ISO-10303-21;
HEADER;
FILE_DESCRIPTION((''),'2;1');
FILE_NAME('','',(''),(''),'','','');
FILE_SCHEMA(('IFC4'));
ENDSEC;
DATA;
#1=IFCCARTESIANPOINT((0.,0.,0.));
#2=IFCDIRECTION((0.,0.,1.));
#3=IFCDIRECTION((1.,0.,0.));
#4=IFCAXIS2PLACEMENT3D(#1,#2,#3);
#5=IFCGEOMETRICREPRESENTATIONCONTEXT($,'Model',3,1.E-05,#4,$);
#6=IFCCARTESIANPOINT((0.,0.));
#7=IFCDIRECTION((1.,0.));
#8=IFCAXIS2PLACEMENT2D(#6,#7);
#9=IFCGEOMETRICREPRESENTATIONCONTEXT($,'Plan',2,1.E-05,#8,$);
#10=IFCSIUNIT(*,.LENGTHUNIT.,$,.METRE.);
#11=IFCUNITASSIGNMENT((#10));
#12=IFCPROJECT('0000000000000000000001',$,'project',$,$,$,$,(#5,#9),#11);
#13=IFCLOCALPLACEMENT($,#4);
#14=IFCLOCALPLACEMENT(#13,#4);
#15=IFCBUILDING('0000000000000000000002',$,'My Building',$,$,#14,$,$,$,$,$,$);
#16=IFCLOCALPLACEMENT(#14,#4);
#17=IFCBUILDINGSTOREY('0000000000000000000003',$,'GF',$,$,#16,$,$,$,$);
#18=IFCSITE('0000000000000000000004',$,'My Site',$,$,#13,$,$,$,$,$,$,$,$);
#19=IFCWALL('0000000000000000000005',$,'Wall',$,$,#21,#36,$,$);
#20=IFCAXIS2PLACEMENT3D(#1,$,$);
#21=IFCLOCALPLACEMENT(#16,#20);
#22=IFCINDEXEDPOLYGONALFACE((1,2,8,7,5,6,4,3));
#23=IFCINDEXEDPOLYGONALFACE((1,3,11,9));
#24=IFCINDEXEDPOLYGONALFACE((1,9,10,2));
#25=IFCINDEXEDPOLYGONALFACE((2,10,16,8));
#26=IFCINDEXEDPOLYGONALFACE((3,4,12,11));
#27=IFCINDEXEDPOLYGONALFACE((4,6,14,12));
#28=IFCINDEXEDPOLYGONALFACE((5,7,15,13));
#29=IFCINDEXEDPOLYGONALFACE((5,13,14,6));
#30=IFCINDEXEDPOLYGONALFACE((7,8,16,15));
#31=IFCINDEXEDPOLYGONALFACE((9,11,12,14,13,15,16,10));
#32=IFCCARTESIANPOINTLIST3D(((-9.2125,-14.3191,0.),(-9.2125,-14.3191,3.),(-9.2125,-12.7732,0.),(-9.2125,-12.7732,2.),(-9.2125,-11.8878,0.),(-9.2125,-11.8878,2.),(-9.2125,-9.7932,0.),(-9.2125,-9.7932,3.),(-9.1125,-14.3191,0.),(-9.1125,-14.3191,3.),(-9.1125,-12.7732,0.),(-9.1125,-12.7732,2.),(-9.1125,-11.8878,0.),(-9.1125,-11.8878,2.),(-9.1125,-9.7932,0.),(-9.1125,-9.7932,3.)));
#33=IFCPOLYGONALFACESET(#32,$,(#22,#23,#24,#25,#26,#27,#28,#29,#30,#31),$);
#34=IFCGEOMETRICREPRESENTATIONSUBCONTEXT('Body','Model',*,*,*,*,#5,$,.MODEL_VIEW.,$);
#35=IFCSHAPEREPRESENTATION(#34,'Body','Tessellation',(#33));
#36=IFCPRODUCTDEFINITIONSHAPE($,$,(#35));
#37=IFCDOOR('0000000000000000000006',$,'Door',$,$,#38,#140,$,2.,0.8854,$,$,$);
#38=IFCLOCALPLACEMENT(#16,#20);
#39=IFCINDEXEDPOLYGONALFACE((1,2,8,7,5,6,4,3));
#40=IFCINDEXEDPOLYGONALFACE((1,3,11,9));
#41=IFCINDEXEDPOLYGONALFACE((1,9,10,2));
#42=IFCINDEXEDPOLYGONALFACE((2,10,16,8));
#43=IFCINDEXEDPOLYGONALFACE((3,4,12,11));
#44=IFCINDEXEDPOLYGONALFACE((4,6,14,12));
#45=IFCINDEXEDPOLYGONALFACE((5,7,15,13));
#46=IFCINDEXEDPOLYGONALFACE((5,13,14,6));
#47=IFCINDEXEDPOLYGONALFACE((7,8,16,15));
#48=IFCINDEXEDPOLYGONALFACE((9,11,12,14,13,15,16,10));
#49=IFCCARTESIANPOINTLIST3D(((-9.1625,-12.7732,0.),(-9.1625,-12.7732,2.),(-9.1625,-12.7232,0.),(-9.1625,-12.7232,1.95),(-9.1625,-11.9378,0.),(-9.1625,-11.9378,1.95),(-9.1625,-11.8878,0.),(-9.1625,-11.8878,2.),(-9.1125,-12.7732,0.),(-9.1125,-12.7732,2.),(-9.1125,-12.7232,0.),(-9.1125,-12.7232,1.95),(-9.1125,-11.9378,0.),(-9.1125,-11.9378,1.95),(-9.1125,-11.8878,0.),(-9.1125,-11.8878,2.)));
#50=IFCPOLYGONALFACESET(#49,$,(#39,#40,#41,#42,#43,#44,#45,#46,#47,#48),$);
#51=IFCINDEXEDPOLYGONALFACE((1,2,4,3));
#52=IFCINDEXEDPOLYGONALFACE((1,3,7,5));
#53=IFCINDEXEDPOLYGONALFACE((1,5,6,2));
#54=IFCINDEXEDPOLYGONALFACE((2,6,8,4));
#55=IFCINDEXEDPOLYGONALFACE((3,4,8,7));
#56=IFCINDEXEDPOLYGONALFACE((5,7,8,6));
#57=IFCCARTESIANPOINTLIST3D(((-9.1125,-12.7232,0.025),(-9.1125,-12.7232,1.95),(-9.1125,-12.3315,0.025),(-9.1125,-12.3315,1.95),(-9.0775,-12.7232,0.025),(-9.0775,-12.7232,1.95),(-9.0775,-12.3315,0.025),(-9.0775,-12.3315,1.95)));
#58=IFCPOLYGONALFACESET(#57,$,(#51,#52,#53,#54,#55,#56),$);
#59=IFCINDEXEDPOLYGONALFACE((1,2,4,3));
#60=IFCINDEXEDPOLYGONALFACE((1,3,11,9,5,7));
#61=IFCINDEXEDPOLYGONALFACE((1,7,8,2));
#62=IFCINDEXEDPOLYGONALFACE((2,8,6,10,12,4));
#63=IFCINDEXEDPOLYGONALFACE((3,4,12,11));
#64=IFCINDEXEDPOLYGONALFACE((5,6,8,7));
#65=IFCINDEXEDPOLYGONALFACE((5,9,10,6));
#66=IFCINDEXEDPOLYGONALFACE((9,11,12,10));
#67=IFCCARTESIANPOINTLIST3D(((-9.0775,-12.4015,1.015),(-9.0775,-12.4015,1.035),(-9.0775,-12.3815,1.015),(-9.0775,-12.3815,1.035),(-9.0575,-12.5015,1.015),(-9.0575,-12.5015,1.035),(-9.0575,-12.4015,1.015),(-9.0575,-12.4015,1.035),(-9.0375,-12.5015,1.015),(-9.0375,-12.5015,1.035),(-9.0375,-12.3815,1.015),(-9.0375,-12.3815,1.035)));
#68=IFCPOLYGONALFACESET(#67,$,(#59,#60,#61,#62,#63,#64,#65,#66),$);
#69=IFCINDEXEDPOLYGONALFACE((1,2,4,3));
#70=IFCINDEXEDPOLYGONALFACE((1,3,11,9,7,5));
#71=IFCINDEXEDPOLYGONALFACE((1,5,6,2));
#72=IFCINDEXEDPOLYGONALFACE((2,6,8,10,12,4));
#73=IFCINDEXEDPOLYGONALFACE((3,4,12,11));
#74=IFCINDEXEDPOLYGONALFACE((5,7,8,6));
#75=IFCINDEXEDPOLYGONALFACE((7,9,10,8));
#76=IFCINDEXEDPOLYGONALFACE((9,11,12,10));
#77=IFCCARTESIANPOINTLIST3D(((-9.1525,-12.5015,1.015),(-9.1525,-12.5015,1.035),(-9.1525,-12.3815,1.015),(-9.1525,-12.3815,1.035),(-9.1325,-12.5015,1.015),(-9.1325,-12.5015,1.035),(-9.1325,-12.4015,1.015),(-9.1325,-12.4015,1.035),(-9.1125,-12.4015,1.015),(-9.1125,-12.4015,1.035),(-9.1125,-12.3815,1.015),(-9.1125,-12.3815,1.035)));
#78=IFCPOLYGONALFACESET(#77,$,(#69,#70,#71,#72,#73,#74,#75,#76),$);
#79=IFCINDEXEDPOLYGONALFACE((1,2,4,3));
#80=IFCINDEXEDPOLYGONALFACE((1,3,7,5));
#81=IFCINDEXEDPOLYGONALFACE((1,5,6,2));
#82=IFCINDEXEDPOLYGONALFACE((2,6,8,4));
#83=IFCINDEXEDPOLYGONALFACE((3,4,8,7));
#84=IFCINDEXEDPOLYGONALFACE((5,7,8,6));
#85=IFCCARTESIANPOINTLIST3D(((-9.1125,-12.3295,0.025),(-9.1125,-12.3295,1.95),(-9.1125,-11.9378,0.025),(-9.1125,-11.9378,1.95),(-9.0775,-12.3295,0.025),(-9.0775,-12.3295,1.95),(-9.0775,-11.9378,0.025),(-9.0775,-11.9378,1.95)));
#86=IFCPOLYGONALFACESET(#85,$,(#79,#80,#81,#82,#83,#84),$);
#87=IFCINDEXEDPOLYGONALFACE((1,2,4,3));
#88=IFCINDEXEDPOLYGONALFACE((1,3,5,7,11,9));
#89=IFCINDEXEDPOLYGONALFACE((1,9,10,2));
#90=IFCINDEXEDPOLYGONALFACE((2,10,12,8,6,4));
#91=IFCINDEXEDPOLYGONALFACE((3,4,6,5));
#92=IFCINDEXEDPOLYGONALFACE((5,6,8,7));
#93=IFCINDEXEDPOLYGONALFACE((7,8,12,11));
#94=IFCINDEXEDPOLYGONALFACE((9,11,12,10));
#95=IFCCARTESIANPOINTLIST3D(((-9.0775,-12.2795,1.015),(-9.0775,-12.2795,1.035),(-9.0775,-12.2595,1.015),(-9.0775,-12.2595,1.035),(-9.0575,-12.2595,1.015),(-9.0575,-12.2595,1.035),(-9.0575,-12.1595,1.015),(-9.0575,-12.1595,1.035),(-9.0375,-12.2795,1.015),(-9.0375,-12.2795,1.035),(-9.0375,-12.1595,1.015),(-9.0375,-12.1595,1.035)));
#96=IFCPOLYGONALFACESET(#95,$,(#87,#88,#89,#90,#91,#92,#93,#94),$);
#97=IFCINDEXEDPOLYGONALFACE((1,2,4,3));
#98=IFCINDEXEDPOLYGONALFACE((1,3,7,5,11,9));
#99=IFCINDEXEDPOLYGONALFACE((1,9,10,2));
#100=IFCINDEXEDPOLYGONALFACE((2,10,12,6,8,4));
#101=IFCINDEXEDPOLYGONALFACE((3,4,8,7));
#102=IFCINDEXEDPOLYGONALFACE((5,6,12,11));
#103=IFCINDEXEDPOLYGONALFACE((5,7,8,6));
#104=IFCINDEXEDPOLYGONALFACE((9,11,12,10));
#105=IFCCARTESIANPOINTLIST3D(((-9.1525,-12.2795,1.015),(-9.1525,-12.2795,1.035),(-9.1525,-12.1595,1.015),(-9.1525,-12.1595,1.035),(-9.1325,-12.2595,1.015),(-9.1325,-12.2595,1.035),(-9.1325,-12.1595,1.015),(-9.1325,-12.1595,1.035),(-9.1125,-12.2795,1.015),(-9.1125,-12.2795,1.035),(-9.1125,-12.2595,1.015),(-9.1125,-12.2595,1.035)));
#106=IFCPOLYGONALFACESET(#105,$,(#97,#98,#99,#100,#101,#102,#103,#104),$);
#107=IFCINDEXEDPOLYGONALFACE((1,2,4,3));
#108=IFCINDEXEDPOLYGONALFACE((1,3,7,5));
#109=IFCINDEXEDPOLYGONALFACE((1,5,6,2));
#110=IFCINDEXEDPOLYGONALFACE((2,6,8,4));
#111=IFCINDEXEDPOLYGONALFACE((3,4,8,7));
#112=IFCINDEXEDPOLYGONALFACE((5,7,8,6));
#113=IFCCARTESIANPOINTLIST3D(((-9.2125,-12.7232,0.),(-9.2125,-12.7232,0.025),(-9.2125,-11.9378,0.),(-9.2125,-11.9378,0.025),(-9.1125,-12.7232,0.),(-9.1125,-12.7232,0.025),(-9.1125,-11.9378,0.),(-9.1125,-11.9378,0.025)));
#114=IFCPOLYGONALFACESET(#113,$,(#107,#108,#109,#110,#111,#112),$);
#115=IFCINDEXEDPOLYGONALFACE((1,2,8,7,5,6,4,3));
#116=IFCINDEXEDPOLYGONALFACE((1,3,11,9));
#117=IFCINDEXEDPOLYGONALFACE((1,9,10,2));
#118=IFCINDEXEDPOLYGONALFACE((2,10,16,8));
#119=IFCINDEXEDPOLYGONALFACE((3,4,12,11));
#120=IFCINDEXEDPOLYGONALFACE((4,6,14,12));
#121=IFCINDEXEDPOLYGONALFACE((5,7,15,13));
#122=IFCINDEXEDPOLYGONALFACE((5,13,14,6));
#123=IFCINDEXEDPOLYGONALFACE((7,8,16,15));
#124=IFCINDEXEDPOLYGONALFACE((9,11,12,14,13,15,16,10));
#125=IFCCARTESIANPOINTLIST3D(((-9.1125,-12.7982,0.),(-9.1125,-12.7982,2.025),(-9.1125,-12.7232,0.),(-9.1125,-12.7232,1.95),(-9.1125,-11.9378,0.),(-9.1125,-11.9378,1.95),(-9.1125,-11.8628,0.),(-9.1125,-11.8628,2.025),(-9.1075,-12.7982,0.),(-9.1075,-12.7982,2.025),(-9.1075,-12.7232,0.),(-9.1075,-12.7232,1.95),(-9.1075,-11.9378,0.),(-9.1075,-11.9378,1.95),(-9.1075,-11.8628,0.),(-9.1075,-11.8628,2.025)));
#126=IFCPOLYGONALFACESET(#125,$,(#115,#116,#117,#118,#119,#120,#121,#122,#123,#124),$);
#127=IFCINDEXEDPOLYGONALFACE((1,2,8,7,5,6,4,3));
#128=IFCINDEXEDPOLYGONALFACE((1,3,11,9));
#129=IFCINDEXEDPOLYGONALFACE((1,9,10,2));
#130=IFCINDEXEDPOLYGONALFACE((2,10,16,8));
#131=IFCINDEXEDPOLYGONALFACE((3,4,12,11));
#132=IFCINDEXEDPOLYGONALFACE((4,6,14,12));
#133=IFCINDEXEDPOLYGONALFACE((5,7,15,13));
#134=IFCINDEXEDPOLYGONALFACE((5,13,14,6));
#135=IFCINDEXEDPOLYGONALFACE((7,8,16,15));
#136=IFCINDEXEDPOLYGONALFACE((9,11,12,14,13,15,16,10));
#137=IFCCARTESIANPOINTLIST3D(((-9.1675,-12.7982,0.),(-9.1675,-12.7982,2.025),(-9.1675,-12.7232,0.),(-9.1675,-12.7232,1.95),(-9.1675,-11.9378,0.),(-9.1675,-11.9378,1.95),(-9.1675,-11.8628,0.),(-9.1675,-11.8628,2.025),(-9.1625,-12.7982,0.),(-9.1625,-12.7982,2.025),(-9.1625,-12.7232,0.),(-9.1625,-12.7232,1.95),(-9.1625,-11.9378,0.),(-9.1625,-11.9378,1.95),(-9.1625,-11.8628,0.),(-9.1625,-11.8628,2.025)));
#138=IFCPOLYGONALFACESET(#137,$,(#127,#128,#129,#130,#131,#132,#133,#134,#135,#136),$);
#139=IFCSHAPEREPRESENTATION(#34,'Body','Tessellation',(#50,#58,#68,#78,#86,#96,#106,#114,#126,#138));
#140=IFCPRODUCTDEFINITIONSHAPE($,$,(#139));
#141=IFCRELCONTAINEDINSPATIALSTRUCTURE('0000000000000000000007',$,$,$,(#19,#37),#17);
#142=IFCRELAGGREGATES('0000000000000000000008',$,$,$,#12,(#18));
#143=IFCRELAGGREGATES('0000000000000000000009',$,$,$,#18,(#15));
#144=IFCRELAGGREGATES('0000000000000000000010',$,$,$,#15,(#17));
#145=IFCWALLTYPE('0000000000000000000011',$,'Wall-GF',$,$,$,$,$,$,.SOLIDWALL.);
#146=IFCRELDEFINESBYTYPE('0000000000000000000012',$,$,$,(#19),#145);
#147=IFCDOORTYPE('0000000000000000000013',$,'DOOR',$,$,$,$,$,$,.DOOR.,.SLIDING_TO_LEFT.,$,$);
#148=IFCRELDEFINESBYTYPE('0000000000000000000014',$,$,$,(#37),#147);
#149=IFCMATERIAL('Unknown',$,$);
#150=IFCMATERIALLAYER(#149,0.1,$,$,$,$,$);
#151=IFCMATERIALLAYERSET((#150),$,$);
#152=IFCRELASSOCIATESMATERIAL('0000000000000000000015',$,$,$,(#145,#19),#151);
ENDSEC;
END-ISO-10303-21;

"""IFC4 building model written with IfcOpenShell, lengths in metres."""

from ifc_helpers import new_model, entity, si_unit, frame, origin_with_axes, origin_2d_with_axis, place, context, subcontext, project, spatial, line, indexed_curve, outline, extrude, shape, source, transform, mapped, material, layer, layer_set, layer_usage, type_object, type_shapes, element, fill, save


model = new_model("IFC4")

# Units and contexts
model_context = context("Model", 3, precision=1e-05, world=origin_with_axes())
plan_context = context("Plan", 2, precision=1e-05, world=origin_2d_with_axis())
body_context_1 = subcontext(model_context, "Body", "Model", "MODEL_VIEW")
body_context_2 = subcontext(plan_context, "Body", "Plan", "PLAN_VIEW")
ifc_project = project(units=[si_unit("LENGTHUNIT", "METRE")], contexts=[model_context, plan_context])

# Site, building, storey
site_placement = place(None, origin_with_axes())
site = spatial("IfcSite", under=ifc_project, at=site_placement, Name="My Site")
building_placement = place(site_placement, origin_with_axes())
building = spatial("IfcBuilding", under=site, at=building_placement, Name="My Building")
storey_placement = place(building_placement, origin_with_axes())
storey = spatial("IfcBuildingStorey", under=building, at=storey_placement, Name="GF")

# Shared definitions
ifc_material = material(Name="Unknown")

# Shared definitions
ifc_layer_1 = layer(ifc_material, 0.1)
ifc_layer_set_1 = layer_set([ifc_layer_1])
wall_type = type_object("IfcWallType", Name="Wall-GF", PredefinedType="SOLIDWALL", material=ifc_layer_set_1)

# Wall, opening, door
shared_shape_1 = source(origin_with_axes(), body_context_1, "Body", "SweptSolid", [
    extrude(outline(indexed_curve([(0.0, 0.0), (0.8854, 0.0), (0.8854, 2.0), (0.0, 2.0)], segments=[line(1, 2, 3, 4, 1)])), frame((0.0, -0.6, 0.0), z_axis=(0.0, -1.0, 0.0), x_axis=(1.0, 0.0, 0.0)), (0.0, 0.0, -1.0), 1.2),
])
door_type_1 = type_object("IfcDoorType", Name="DOOR", OperationType="SLIDING_TO_LEFT", PredefinedType="DOOR")
shared_shape_2 = source(origin_with_axes(), body_context_1, "Body", "SweptSolid", [
    extrude(outline(indexed_curve([(0.0, 0.0), (0.0, 2.0), (0.8854, 2.0), (0.8854, 0.0), (0.8354, 0.0), (0.8354, 1.95), (0.05, 1.95), (0.05, 0.0)], segments=[line(1, 2, 3, 4, 5, 6, 7, 8, 1)])), frame((0.0, 0.0, 0.0), z_axis=(0.0, -1.0, 0.0), x_axis=(1.0, 0.0, 0.0)), (0.0, 0.0, -1.0), 0.05),
    extrude(outline(indexed_curve([(0.0, 0.0), (0.3917, 0.0), (0.3917, 0.035), (0.0, 0.035)], segments=[line(1, 2, 3, 4, 1)])), frame((0.05, -0.035, 0.025), z_axis=(0.0, 0.0, 1.0), x_axis=(1.0, 0.0, 0.0)), (0.0, 0.0, 1.0), 1.925),
    extrude(outline(indexed_curve([(0.0, 0.0), (0.0, -0.04), (-0.12, -0.04), (-0.12, -0.02), (-0.02, -0.02), (-0.02, 0.0)], segments=[line(1, 2, 3, 4, 5, 6, 1)])), frame((0.3917, -0.035, 1.015), z_axis=(0.0, 0.0, 1.0), x_axis=(1.0, 0.0, 0.0)), (0.0, 0.0, 1.0), 0.02),
    extrude(outline(indexed_curve([(0.0, 0.0), (0.0, 0.04), (-0.12, 0.04), (-0.12, 0.02), (-0.02, 0.02), (-0.02, 0.0)], segments=[line(1, 2, 3, 4, 5, 6, 1)])), frame((0.3917, 0.0, 1.015), z_axis=(0.0, 0.0, 1.0), x_axis=(1.0, 0.0, 0.0)), (0.0, 0.0, 1.0), 0.02),
    extrude(outline(indexed_curve([(0.0, 0.0), (-0.3917, 0.0), (-0.3917, 0.035), (0.0, 0.035)], segments=[line(1, 2, 3, 4, 1)])), frame((0.8354, -0.035, 0.025), z_axis=(0.0, 0.0, 1.0), x_axis=(1.0, 0.0, 0.0)), (0.0, 0.0, 1.0), 1.925),
    extrude(outline(indexed_curve([(0.0, 0.0), (0.0, -0.04), (0.12, -0.04), (0.12, -0.02), (0.02, -0.02), (0.02, 0.0)], segments=[line(1, 2, 3, 4, 5, 6, 1)])), frame((0.4937, -0.035, 1.015), z_axis=(0.0, 0.0, 1.0), x_axis=(1.0, 0.0, 0.0)), (0.0, 0.0, 1.0), 0.02),
    extrude(outline(indexed_curve([(0.0, 0.0), (0.0, 0.04), (0.12, 0.04), (0.12, 0.02), (0.02, 0.02), (0.02, 0.0)], segments=[line(1, 2, 3, 4, 5, 6, 1)])), frame((0.4937, 0.0, 1.015), z_axis=(0.0, 0.0, 1.0), x_axis=(1.0, 0.0, 0.0)), (0.0, 0.0, 1.0), 0.02),
    extrude(outline(indexed_curve([(0.0, 0.0), (0.7854, 0.0), (0.7854, 0.1), (0.0, 0.1)], segments=[line(1, 2, 3, 4, 1)])), frame((0.05, 0.0, 0.0), z_axis=(0.0, 0.0, 1.0), x_axis=(1.0, 0.0, 0.0)), (0.0, 0.0, 1.0), 0.025),
    extrude(outline(indexed_curve([(0.0, 0.0), (0.0, 2.025), (0.9354, 2.025), (0.9354, 0.0), (0.8604, 0.0), (0.8604, 1.95), (0.075, 1.95), (0.075, 0.0)], segments=[line(1, 2, 3, 4, 5, 6, 7, 8, 1)])), frame((-0.025, -0.005, 0.0), z_axis=(0.0, -1.0, 0.0), x_axis=(1.0, 0.0, 0.0)), (0.0, 0.0, -1.0), 0.005),
    extrude(outline(indexed_curve([(0.0, 0.0), (0.0, 2.025), (0.9354, 2.025), (0.9354, 0.0), (0.8604, 0.0), (0.8604, 1.95), (0.075, 1.95), (0.075, 0.0)], segments=[line(1, 2, 3, 4, 5, 6, 7, 8, 1)])), frame((-0.025, 0.05, 0.0), z_axis=(0.0, -1.0, 0.0), x_axis=(1.0, 0.0, 0.0)), (0.0, 0.0, -1.0), 0.005),
])
shared_shape_3 = source(origin_with_axes(), body_context_2, "Body", "Curve2D", [
    entity("IfcIndexedPolyCurve", entity("IfcCartesianPointList2D", [[0.0, 0.0], [0.05, 0.0], [0.05, 0.05], [0.0, 0.05]]), [entity("IfcLineIndex", [1, 2, 3, 4, 1])]),
    entity("IfcIndexedPolyCurve", entity("IfcCartesianPointList2D", [[0.8854, 0.0], [0.8354, 0.0], [0.8354, 0.05], [0.8854, 0.05]]), [entity("IfcLineIndex", [1, 2, 3, 4, 1])]),
    entity("IfcIndexedPolyCurve", entity("IfcCartesianPointList2D", [[-0.1464, -0.035], [0.2464, -0.035], [0.2464, 0.0], [-0.1464, 0.0]]), [entity("IfcLineIndex", [1, 2, 3, 4, 1])]),
    entity("IfcIndexedPolyCurve", entity("IfcCartesianPointList2D", [[1.0318, -0.035], [0.6391, -0.035], [0.6391, 0.0], [1.0318, 0.0]]), [entity("IfcLineIndex", [1, 2, 3, 4, 1])]),
])
type_shapes(door_type_1, [shared_shape_2, shared_shape_3])
ifc_layer_usage_1 = layer_usage(ifc_layer_set_1, "AXIS2", "POSITIVE", 0.0)
wall_1_placement = place(storey_placement, frame((-9.2125, -9.7932, 0.0), z_axis=(0.0, 0.0, 1.0), x_axis=(0.0, -1.0, 0.0)))
wall_1 = element("IfcWall", 1, at=wall_1_placement, inside=storey, type_object=wall_type, material=ifc_layer_usage_1, Name="Wall", context=body_context_1, shape_type="SweptSolid", body=[
    extrude(outline(indexed_curve([(0.0, 0.0), (0.0, 0.1), (4.5259, 0.1), (4.5259, 0.0)], segments=[line(1, 2, 3, 4, 1)])), origin_with_axes(), (0.0, 0.0, 1.0), 3.0),
])
opening_1_placement = place(wall_1_placement, frame((2.98, 0.1, 0.0), z_axis=(0.0, 0.0, 1.0), x_axis=(-1.0, 0.0, 0.0)))
opening_1 = element("IfcOpeningElement", 2, at=opening_1_placement, cuts=wall_1, PredefinedType="OPENING", context=body_context_1, shape_type="MappedRepresentation", body=[
    mapped(shared_shape_1, transform((0.0, 0.0, 0.0), x_axis=(1.0, 0.0, 0.0), y_axis=(0.0, 1.0, 0.0), z_axis=(0.0, 0.0, 1.0), scale=1.0)),
])
door_1_placement = place(opening_1_placement, frame((0.0, 0.0, 0.0), z_axis=(0.0, 0.0, 1.0), x_axis=(1.0, 0.0, 0.0)))
door_1 = element("IfcDoor", 3, at=door_1_placement, inside=storey, type_object=door_type_1, Name="Door", OverallHeight=2.0, OverallWidth=0.8854, shapes=[
    shape(body_context_1, "Body", "MappedRepresentation", [mapped(shared_shape_2, transform((0.0, 0.0, 0.0), x_axis=(1.0, 0.0, 0.0), y_axis=(0.0, 1.0, 0.0), z_axis=(0.0, 0.0, 1.0), scale=1.0))]),
    shape(body_context_2, "Body", "MappedRepresentation", [mapped(shared_shape_3, transform((0.0, 0.0, 0.0), x_axis=(1.0, 0.0, 0.0), y_axis=(0.0, 1.0, 0.0), z_axis=(0.0, 0.0, 1.0), scale=1.0))]),
])
fill(opening_1, door_1)

save(model, "model.ifc")
